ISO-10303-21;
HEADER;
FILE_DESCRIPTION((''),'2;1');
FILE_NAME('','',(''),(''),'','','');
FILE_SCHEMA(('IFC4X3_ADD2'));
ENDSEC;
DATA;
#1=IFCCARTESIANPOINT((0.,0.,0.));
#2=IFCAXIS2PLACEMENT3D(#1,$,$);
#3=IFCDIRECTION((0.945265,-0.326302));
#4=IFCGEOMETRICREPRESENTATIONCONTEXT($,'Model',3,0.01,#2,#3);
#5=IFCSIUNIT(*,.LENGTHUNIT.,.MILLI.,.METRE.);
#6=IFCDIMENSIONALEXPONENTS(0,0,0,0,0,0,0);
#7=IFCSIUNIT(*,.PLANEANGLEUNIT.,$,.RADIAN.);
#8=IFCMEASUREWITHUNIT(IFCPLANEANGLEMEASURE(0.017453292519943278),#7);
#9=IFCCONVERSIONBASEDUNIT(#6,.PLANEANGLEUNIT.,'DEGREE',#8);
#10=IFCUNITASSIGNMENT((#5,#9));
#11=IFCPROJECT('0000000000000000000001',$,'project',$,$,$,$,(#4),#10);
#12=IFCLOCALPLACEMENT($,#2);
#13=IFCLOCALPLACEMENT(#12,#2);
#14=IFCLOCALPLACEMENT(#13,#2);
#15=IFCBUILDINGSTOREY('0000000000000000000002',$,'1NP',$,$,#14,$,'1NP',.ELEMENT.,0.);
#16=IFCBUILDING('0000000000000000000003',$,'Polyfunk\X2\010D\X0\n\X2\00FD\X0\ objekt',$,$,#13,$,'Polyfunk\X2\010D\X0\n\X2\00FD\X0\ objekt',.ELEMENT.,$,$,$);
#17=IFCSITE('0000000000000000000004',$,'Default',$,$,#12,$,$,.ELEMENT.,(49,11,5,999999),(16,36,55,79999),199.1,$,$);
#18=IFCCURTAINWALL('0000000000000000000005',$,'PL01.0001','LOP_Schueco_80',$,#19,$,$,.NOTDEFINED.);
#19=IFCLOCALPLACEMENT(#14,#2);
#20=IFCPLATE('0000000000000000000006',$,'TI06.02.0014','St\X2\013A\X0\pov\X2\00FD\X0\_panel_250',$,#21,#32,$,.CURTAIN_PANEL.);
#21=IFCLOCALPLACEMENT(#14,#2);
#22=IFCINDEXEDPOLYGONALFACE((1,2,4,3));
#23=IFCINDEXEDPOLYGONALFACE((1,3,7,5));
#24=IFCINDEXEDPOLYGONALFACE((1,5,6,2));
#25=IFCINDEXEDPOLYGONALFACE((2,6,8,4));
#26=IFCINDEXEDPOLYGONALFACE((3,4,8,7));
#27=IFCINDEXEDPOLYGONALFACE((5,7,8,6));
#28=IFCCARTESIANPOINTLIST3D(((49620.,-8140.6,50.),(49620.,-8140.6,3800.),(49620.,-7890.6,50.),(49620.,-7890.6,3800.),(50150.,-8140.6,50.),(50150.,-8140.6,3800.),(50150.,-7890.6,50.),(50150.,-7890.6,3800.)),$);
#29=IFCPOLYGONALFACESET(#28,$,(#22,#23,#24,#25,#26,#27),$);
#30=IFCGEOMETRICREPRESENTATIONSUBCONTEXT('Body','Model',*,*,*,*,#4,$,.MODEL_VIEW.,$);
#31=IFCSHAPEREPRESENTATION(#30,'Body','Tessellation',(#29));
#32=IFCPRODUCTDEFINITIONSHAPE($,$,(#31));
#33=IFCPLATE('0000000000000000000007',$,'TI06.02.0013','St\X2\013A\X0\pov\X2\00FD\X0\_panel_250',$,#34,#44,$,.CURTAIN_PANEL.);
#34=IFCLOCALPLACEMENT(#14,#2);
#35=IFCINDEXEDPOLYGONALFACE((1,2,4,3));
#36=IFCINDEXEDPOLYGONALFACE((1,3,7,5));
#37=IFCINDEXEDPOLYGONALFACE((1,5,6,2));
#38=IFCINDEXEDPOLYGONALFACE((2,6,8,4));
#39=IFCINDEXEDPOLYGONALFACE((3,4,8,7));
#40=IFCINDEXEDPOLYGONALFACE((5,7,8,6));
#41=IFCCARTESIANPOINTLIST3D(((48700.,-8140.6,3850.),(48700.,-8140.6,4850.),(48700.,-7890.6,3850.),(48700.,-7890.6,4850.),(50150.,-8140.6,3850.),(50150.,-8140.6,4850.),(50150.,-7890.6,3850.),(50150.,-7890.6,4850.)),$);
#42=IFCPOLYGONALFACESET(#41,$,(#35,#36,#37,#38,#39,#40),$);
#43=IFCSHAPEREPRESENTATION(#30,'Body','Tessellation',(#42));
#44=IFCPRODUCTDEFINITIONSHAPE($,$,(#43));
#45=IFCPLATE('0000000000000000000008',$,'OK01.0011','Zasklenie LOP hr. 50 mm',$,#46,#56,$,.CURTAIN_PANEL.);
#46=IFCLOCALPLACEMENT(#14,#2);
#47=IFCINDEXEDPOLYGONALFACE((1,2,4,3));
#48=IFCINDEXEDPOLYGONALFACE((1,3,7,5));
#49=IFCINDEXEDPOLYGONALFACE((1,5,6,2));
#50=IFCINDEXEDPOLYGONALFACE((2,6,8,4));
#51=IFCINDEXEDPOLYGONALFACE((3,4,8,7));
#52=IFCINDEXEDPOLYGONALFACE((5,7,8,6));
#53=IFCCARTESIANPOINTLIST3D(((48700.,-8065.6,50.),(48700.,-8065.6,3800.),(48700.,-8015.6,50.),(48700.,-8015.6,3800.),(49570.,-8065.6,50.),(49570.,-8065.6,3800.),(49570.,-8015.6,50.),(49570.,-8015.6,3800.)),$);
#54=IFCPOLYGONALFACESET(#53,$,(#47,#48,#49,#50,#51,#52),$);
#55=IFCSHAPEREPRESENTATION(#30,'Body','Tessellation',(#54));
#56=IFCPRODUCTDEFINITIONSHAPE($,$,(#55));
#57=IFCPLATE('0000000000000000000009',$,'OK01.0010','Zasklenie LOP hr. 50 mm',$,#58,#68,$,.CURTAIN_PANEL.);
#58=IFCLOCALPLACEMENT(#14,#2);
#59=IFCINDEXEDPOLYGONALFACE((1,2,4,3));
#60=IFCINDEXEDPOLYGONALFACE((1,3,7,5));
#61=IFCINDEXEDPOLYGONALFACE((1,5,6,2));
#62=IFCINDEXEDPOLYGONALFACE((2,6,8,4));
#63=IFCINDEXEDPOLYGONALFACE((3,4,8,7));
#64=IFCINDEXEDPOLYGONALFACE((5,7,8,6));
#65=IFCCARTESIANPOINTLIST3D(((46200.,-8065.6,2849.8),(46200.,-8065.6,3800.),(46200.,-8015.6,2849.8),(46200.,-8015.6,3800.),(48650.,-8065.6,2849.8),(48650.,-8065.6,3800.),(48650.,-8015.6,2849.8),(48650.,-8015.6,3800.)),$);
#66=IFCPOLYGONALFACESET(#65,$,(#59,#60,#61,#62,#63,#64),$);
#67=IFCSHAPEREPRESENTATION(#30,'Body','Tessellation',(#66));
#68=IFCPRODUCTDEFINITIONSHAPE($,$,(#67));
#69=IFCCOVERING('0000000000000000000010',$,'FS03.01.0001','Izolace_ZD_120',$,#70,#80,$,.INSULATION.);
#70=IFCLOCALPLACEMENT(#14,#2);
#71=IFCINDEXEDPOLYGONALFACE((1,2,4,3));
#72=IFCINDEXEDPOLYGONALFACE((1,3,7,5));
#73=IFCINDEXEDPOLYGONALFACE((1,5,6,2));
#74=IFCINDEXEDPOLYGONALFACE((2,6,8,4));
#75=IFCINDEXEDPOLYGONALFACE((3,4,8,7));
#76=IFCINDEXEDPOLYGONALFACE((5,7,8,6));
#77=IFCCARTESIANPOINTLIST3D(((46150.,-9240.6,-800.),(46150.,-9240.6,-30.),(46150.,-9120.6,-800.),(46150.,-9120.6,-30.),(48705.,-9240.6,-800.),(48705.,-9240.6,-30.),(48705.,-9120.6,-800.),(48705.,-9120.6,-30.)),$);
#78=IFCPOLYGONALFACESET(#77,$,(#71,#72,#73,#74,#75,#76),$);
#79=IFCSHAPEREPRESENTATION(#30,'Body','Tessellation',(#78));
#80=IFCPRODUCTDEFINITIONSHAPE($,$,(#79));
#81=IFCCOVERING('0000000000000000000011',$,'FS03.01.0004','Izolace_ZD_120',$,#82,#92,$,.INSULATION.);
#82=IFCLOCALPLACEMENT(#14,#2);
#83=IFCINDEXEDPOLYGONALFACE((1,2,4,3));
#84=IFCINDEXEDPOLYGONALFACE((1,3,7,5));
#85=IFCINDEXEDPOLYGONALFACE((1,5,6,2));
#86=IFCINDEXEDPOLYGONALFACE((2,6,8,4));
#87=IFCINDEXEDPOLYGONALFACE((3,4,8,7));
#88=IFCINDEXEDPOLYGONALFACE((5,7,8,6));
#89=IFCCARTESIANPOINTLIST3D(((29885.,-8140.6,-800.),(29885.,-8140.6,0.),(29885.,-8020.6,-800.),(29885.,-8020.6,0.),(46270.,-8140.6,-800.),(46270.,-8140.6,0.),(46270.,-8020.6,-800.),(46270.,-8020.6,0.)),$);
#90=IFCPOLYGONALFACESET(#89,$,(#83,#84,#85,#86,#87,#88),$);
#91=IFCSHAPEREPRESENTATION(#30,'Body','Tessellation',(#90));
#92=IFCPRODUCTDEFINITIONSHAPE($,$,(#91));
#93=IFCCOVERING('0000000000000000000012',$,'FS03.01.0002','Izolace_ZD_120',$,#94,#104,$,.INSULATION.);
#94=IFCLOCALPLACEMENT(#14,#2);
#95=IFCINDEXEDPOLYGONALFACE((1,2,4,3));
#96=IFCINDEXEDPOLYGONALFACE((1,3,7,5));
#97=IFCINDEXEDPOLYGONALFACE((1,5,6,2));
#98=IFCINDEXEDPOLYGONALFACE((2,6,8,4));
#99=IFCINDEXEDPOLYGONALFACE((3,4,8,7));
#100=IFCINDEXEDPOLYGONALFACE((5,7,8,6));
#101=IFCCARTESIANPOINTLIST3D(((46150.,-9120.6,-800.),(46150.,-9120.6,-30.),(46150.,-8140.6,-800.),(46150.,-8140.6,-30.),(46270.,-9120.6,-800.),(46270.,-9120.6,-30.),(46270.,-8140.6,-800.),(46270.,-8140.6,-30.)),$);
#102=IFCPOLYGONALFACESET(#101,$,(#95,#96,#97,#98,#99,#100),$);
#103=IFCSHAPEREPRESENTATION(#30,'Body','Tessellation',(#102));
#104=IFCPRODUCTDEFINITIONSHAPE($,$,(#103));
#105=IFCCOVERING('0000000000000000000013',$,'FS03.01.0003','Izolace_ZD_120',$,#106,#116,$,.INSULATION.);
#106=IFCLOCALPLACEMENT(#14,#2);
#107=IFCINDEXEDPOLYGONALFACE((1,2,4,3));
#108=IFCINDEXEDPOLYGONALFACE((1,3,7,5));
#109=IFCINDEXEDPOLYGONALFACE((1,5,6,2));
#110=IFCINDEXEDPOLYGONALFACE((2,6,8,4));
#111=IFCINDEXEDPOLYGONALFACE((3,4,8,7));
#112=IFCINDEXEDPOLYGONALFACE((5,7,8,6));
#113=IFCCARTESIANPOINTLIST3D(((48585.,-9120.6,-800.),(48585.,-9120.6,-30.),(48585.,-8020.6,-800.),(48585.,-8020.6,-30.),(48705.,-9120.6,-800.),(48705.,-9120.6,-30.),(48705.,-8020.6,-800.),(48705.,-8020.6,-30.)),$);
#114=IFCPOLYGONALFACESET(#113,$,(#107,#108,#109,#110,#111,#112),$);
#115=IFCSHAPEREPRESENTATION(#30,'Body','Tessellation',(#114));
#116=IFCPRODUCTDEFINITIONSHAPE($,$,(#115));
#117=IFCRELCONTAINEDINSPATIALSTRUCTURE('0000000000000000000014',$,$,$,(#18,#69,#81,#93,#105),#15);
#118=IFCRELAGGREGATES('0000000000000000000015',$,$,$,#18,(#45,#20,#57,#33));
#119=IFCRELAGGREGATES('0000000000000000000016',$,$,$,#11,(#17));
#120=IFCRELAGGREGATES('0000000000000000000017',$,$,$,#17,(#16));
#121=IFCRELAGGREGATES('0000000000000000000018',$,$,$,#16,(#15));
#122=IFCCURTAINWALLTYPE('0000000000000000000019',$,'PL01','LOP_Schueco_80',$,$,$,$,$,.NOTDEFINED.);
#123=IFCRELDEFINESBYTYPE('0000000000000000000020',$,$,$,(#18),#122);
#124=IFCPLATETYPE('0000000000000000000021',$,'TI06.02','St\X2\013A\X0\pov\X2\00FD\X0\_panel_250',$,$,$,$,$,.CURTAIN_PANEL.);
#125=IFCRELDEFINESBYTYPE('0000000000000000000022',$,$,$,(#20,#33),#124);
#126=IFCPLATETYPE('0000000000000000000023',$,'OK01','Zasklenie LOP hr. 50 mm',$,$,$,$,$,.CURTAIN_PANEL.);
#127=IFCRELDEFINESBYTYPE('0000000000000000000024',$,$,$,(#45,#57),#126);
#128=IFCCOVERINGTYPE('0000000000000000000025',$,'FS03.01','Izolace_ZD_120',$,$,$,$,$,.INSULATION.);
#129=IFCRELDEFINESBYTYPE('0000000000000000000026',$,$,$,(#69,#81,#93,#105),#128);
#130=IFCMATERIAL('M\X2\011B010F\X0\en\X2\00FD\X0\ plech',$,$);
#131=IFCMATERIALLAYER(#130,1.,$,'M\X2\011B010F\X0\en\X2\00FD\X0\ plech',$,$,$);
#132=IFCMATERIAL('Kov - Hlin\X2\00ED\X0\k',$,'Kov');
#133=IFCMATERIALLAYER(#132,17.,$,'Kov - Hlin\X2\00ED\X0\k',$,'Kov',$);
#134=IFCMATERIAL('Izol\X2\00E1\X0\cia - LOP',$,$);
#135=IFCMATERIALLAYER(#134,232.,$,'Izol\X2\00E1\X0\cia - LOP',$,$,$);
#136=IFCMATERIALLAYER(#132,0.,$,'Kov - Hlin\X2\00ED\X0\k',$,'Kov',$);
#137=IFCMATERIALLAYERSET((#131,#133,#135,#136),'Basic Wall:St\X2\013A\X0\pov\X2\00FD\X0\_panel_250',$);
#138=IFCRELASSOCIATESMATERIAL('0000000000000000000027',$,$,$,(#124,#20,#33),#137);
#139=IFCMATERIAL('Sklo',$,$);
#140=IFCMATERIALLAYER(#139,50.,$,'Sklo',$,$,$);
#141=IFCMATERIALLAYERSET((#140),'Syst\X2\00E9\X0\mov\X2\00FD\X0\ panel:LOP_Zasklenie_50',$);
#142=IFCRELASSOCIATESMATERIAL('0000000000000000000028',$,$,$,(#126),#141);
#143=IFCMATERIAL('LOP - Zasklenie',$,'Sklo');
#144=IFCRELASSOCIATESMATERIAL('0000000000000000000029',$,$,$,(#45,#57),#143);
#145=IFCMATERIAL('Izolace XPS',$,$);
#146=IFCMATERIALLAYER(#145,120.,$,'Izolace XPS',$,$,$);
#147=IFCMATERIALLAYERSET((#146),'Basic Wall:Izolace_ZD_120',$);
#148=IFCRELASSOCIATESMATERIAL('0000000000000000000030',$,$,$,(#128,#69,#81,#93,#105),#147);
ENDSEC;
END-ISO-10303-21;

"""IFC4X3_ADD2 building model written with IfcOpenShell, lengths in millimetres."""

from ifc_helpers import new_model, entity, si_unit, converted_unit, direction, frame, frame_2d, origin, origin_2d_with_axis, place, context, subcontext, project, spatial, rectangle, extrude, source, transform, mapped, material, layer, layer_set, layer_usage, type_object, type_shapes, element, aggregate, save


model = new_model("IFC4X3_ADD2")

# Units and contexts
model_context = context("Model", 3, precision=0.01, world=origin(), true_north=direction((0.945265, -0.326302)))
body_context = subcontext(model_context, "Body", "Model", "MODEL_VIEW")
ifc_project = project(units=[si_unit("LENGTHUNIT", "METRE", prefix="MILLI"), converted_unit("PLANEANGLEUNIT", "DEGREE", entity("IfcPlaneAngleMeasure", 0.017453292519943278), si_unit("PLANEANGLEUNIT", "RADIAN"), dimensions=[0, 0, 0, 0, 0, 0, 0])], contexts=[model_context])

# Site, building, storey
site_placement = place(None, origin())
site = spatial("IfcSite", under=ifc_project, at=site_placement, Name="Default", CompositionType="ELEMENT", RefLatitude=(49, 11, 5, 999999), RefLongitude=(16, 36, 55, 79999), RefElevation=199.1)
building_placement = place(site_placement, origin())
building = spatial("IfcBuilding", under=site, at=building_placement, Name="Polyfunkčný objekt", LongName="Polyfunkčný objekt", CompositionType="ELEMENT")
storey_placement = place(building_placement, origin())
storey = spatial("IfcBuildingStorey", under=building, at=storey_placement, Name="1NP", LongName="1NP", CompositionType="ELEMENT", Elevation=0.0)

# Curtain wall, plates
curtain_wall_type = type_object("IfcCurtainWallType", Name="PL01", Description="LOP_Schueco_80", PredefinedType="NOTDEFINED")
curtain_wall_placement = place(storey_placement, origin())
curtain_wall = element("IfcCurtainWall", 1, at=curtain_wall_placement, inside=storey, type_object=curtain_wall_type, Name="PL01.0001", Description="LOP_Schueco_80", PredefinedType="NOTDEFINED")
ifc_material_1 = material(Name="Měďený plech")
ifc_layer_1 = layer(ifc_material_1, 1.0, Name="Měďený plech")
ifc_material_2 = material(Name="Kov - Hliník", Category="Kov")
ifc_layer_2 = layer(ifc_material_2, 17.0, Name="Kov - Hliník", Category="Kov")
ifc_material_3 = material(Name="Izolácia - LOP")
ifc_layer_3 = layer(ifc_material_3, 232.0, Name="Izolácia - LOP")
ifc_layer_4 = layer(ifc_material_2, 0.0, Name="Kov - Hliník", Category="Kov")
ifc_layer_set_1 = layer_set([ifc_layer_1, ifc_layer_2, ifc_layer_3, ifc_layer_4], Name="Basic Wall:Stĺpový_panel_250")
ifc_layer_usage_1 = layer_usage(ifc_layer_set_1, "AXIS2", "POSITIVE", -125.0)
plate_type_1 = type_object("IfcPlateType", Name="TI06.02", Description="Stĺpový_panel_250", PredefinedType="CURTAIN_PANEL", material=ifc_layer_set_1)
plate_1_placement = place(storey_placement, frame((49620.0, -8015.6, 50.0)))
plate_1 = element("IfcPlate", 2, at=plate_1_placement, type_object=plate_type_1, material=ifc_layer_usage_1, Name="TI06.02.0014", Description="Stĺpový_panel_250", PredefinedType="CURTAIN_PANEL", context=body_context, shape_type="SweptSolid", body=[
    extrude(rectangle(XDim=250.0, YDim=530.0, at=frame_2d((0.0, 0.0), x_axis=(1.0, 0.0))), frame((265.0, 0.0, 0.0), z_axis=(0.0, 0.0, 1.0), x_axis=(0.0, 1.0, 0.0)), (0.0, 0.0, 1.0), 3750.0),
])
ifc_layer_usage_2 = layer_usage(ifc_layer_set_1, "AXIS2", "POSITIVE", -125.0)
plate_2_placement = place(storey_placement, frame((48700.0, -8015.6, 3850.0)))
plate_2 = element("IfcPlate", 3, at=plate_2_placement, type_object=plate_type_1, material=ifc_layer_usage_2, Name="TI06.02.0013", Description="Stĺpový_panel_250", PredefinedType="CURTAIN_PANEL", context=body_context, shape_type="SweptSolid", body=[
    extrude(rectangle(XDim=250.0, YDim=1450.0, at=frame_2d((0.0, 0.0), x_axis=(1.0, 0.0))), frame((725.0, 0.0, 0.0), z_axis=(0.0, 0.0, 1.0), x_axis=(0.0, 1.0, 0.0)), (0.0, 0.0, 1.0), 1000.0),
])
ifc_material_4 = material(Name="LOP - Zasklenie", Category="Sklo")
ifc_material_5 = material(Name="Sklo")
ifc_layer_5 = layer(ifc_material_5, 50.0, Name="Sklo")
ifc_layer_set_2 = layer_set([ifc_layer_5], Name="Systémový panel:LOP_Zasklenie_50")
plate_type_2 = type_object("IfcPlateType", Name="OK01", Description="Zasklenie LOP hr. 50 mm", PredefinedType="CURTAIN_PANEL", material=ifc_layer_set_2)
shared_shape_1 = source(origin(), body_context, "Body", "SweptSolid", [
    extrude(rectangle(XDim=3750.0, YDim=870.0, at=frame_2d((-331.2, 0.0), x_axis=(1.0, 0.0))), frame((0.0, -50.0, 2206.2), z_axis=(0.0, 1.0, 0.0), x_axis=(0.0, 0.0, 1.0)), (0.0, 0.0, 1.0), 50.0),
])
plate_3_placement = place(curtain_wall_placement, frame((49135.0, -8015.6, 50.0)))
plate_3 = element("IfcPlate", 4, at=plate_3_placement, type_object=plate_type_2, material=ifc_material_4, Name="OK01.0011", Description="Zasklenie LOP hr. 50 mm", PredefinedType="CURTAIN_PANEL", context=body_context, shape_type="MappedRepresentation", body=[
    mapped(shared_shape_1, transform((0.0, 0.0, 0.0), scale=1.0)),
])
shared_shape_2 = source(origin(), body_context, "Body", "SweptSolid", [
    extrude(rectangle(XDim=50.0, YDim=2450.0, at=origin_2d_with_axis()), frame((0.0, -25.0, 0.0), z_axis=(0.0, 0.0, 1.0), x_axis=(0.0, 1.0, 0.0)), (0.0, 0.0, 1.0), 950.2),
])
type_shapes(plate_type_2, [shared_shape_1, shared_shape_2])
plate_4_placement = place(curtain_wall_placement, frame((47425.0, -8015.6, 2849.8)))
plate_4 = element("IfcPlate", 5, at=plate_4_placement, type_object=plate_type_2, material=ifc_material_4, Name="OK01.0010", Description="Zasklenie LOP hr. 50 mm", PredefinedType="CURTAIN_PANEL", context=body_context, shape_type="MappedRepresentation", body=[
    mapped(shared_shape_2, transform((0.0, 0.0, 0.0), scale=1.0)),
])
aggregate(curtain_wall, [plate_3, plate_1, plate_4, plate_2])

# Coverings
ifc_material_6 = material(Name="Izolace XPS")
ifc_layer_6 = layer(ifc_material_6, 120.0, Name="Izolace XPS")
ifc_layer_set_3 = layer_set([ifc_layer_6], Name="Basic Wall:Izolace_ZD_120")
covering_type = type_object("IfcCoveringType", Name="FS03.01", Description="Izolace_ZD_120", PredefinedType="INSULATION", material=ifc_layer_set_3)
covering_1_placement = place(storey_placement, frame((48705.0, -9180.6, -800.0), z_axis=(0.0, 0.0, 1.0), x_axis=(-1.0, 0.0, 0.0)))
element("IfcCovering", 6, at=covering_1_placement, inside=storey, type_object=covering_type, material=ifc_layer_set_3, Name="FS03.01.0001", Description="Izolace_ZD_120", PredefinedType="INSULATION", context=body_context, shape_type="SweptSolid", body=[
    extrude(rectangle(XDim=2555.0, YDim=120.0, at=frame_2d((1277.5, 0.0), x_axis=(-1.0, 0.0))), origin(), (0.0, 0.0, 1.0), 770.0),
])
covering_2_placement = place(storey_placement, frame((46270.0, -8080.6, -800.0), z_axis=(0.0, 0.0, 1.0), x_axis=(-1.0, 0.0, 0.0)))
element("IfcCovering", 7, at=covering_2_placement, inside=storey, type_object=covering_type, material=ifc_layer_set_3, Name="FS03.01.0004", Description="Izolace_ZD_120", PredefinedType="INSULATION", context=body_context, shape_type="SweptSolid", body=[
    extrude(rectangle(XDim=16385.0, YDim=120.0, at=frame_2d((8192.5, 0.0), x_axis=(-1.0, 0.0))), origin(), (0.0, 0.0, 1.0), 800.0),
])
covering_3_placement = place(storey_placement, frame((46210.0, -9120.6, -800.0), z_axis=(0.0, 0.0, 1.0), x_axis=(0.0, 1.0, 0.0)))
element("IfcCovering", 8, at=covering_3_placement, inside=storey, type_object=covering_type, material=ifc_layer_set_3, Name="FS03.01.0002", Description="Izolace_ZD_120", PredefinedType="INSULATION", context=body_context, shape_type="SweptSolid", body=[
    extrude(rectangle(XDim=980.0, YDim=120.0, at=frame_2d((490.0, 0.0), x_axis=(-1.0, 0.0))), origin(), (0.0, 0.0, 1.0), 770.0),
])
covering_4_placement = place(storey_placement, frame((48645.0, -9120.6, -800.0), z_axis=(0.0, 0.0, 1.0), x_axis=(0.0, 1.0, 0.0)))
element("IfcCovering", 9, at=covering_4_placement, inside=storey, type_object=covering_type, material=ifc_layer_set_3, Name="FS03.01.0003", Description="Izolace_ZD_120", PredefinedType="INSULATION", context=body_context, shape_type="SweptSolid", body=[
    extrude(rectangle(XDim=1100.0, YDim=120.0, at=frame_2d((550.0, 0.0), x_axis=(-1.0, 0.0))), origin(), (0.0, 0.0, 1.0), 770.0),
])

save(model, "model.ifc")
